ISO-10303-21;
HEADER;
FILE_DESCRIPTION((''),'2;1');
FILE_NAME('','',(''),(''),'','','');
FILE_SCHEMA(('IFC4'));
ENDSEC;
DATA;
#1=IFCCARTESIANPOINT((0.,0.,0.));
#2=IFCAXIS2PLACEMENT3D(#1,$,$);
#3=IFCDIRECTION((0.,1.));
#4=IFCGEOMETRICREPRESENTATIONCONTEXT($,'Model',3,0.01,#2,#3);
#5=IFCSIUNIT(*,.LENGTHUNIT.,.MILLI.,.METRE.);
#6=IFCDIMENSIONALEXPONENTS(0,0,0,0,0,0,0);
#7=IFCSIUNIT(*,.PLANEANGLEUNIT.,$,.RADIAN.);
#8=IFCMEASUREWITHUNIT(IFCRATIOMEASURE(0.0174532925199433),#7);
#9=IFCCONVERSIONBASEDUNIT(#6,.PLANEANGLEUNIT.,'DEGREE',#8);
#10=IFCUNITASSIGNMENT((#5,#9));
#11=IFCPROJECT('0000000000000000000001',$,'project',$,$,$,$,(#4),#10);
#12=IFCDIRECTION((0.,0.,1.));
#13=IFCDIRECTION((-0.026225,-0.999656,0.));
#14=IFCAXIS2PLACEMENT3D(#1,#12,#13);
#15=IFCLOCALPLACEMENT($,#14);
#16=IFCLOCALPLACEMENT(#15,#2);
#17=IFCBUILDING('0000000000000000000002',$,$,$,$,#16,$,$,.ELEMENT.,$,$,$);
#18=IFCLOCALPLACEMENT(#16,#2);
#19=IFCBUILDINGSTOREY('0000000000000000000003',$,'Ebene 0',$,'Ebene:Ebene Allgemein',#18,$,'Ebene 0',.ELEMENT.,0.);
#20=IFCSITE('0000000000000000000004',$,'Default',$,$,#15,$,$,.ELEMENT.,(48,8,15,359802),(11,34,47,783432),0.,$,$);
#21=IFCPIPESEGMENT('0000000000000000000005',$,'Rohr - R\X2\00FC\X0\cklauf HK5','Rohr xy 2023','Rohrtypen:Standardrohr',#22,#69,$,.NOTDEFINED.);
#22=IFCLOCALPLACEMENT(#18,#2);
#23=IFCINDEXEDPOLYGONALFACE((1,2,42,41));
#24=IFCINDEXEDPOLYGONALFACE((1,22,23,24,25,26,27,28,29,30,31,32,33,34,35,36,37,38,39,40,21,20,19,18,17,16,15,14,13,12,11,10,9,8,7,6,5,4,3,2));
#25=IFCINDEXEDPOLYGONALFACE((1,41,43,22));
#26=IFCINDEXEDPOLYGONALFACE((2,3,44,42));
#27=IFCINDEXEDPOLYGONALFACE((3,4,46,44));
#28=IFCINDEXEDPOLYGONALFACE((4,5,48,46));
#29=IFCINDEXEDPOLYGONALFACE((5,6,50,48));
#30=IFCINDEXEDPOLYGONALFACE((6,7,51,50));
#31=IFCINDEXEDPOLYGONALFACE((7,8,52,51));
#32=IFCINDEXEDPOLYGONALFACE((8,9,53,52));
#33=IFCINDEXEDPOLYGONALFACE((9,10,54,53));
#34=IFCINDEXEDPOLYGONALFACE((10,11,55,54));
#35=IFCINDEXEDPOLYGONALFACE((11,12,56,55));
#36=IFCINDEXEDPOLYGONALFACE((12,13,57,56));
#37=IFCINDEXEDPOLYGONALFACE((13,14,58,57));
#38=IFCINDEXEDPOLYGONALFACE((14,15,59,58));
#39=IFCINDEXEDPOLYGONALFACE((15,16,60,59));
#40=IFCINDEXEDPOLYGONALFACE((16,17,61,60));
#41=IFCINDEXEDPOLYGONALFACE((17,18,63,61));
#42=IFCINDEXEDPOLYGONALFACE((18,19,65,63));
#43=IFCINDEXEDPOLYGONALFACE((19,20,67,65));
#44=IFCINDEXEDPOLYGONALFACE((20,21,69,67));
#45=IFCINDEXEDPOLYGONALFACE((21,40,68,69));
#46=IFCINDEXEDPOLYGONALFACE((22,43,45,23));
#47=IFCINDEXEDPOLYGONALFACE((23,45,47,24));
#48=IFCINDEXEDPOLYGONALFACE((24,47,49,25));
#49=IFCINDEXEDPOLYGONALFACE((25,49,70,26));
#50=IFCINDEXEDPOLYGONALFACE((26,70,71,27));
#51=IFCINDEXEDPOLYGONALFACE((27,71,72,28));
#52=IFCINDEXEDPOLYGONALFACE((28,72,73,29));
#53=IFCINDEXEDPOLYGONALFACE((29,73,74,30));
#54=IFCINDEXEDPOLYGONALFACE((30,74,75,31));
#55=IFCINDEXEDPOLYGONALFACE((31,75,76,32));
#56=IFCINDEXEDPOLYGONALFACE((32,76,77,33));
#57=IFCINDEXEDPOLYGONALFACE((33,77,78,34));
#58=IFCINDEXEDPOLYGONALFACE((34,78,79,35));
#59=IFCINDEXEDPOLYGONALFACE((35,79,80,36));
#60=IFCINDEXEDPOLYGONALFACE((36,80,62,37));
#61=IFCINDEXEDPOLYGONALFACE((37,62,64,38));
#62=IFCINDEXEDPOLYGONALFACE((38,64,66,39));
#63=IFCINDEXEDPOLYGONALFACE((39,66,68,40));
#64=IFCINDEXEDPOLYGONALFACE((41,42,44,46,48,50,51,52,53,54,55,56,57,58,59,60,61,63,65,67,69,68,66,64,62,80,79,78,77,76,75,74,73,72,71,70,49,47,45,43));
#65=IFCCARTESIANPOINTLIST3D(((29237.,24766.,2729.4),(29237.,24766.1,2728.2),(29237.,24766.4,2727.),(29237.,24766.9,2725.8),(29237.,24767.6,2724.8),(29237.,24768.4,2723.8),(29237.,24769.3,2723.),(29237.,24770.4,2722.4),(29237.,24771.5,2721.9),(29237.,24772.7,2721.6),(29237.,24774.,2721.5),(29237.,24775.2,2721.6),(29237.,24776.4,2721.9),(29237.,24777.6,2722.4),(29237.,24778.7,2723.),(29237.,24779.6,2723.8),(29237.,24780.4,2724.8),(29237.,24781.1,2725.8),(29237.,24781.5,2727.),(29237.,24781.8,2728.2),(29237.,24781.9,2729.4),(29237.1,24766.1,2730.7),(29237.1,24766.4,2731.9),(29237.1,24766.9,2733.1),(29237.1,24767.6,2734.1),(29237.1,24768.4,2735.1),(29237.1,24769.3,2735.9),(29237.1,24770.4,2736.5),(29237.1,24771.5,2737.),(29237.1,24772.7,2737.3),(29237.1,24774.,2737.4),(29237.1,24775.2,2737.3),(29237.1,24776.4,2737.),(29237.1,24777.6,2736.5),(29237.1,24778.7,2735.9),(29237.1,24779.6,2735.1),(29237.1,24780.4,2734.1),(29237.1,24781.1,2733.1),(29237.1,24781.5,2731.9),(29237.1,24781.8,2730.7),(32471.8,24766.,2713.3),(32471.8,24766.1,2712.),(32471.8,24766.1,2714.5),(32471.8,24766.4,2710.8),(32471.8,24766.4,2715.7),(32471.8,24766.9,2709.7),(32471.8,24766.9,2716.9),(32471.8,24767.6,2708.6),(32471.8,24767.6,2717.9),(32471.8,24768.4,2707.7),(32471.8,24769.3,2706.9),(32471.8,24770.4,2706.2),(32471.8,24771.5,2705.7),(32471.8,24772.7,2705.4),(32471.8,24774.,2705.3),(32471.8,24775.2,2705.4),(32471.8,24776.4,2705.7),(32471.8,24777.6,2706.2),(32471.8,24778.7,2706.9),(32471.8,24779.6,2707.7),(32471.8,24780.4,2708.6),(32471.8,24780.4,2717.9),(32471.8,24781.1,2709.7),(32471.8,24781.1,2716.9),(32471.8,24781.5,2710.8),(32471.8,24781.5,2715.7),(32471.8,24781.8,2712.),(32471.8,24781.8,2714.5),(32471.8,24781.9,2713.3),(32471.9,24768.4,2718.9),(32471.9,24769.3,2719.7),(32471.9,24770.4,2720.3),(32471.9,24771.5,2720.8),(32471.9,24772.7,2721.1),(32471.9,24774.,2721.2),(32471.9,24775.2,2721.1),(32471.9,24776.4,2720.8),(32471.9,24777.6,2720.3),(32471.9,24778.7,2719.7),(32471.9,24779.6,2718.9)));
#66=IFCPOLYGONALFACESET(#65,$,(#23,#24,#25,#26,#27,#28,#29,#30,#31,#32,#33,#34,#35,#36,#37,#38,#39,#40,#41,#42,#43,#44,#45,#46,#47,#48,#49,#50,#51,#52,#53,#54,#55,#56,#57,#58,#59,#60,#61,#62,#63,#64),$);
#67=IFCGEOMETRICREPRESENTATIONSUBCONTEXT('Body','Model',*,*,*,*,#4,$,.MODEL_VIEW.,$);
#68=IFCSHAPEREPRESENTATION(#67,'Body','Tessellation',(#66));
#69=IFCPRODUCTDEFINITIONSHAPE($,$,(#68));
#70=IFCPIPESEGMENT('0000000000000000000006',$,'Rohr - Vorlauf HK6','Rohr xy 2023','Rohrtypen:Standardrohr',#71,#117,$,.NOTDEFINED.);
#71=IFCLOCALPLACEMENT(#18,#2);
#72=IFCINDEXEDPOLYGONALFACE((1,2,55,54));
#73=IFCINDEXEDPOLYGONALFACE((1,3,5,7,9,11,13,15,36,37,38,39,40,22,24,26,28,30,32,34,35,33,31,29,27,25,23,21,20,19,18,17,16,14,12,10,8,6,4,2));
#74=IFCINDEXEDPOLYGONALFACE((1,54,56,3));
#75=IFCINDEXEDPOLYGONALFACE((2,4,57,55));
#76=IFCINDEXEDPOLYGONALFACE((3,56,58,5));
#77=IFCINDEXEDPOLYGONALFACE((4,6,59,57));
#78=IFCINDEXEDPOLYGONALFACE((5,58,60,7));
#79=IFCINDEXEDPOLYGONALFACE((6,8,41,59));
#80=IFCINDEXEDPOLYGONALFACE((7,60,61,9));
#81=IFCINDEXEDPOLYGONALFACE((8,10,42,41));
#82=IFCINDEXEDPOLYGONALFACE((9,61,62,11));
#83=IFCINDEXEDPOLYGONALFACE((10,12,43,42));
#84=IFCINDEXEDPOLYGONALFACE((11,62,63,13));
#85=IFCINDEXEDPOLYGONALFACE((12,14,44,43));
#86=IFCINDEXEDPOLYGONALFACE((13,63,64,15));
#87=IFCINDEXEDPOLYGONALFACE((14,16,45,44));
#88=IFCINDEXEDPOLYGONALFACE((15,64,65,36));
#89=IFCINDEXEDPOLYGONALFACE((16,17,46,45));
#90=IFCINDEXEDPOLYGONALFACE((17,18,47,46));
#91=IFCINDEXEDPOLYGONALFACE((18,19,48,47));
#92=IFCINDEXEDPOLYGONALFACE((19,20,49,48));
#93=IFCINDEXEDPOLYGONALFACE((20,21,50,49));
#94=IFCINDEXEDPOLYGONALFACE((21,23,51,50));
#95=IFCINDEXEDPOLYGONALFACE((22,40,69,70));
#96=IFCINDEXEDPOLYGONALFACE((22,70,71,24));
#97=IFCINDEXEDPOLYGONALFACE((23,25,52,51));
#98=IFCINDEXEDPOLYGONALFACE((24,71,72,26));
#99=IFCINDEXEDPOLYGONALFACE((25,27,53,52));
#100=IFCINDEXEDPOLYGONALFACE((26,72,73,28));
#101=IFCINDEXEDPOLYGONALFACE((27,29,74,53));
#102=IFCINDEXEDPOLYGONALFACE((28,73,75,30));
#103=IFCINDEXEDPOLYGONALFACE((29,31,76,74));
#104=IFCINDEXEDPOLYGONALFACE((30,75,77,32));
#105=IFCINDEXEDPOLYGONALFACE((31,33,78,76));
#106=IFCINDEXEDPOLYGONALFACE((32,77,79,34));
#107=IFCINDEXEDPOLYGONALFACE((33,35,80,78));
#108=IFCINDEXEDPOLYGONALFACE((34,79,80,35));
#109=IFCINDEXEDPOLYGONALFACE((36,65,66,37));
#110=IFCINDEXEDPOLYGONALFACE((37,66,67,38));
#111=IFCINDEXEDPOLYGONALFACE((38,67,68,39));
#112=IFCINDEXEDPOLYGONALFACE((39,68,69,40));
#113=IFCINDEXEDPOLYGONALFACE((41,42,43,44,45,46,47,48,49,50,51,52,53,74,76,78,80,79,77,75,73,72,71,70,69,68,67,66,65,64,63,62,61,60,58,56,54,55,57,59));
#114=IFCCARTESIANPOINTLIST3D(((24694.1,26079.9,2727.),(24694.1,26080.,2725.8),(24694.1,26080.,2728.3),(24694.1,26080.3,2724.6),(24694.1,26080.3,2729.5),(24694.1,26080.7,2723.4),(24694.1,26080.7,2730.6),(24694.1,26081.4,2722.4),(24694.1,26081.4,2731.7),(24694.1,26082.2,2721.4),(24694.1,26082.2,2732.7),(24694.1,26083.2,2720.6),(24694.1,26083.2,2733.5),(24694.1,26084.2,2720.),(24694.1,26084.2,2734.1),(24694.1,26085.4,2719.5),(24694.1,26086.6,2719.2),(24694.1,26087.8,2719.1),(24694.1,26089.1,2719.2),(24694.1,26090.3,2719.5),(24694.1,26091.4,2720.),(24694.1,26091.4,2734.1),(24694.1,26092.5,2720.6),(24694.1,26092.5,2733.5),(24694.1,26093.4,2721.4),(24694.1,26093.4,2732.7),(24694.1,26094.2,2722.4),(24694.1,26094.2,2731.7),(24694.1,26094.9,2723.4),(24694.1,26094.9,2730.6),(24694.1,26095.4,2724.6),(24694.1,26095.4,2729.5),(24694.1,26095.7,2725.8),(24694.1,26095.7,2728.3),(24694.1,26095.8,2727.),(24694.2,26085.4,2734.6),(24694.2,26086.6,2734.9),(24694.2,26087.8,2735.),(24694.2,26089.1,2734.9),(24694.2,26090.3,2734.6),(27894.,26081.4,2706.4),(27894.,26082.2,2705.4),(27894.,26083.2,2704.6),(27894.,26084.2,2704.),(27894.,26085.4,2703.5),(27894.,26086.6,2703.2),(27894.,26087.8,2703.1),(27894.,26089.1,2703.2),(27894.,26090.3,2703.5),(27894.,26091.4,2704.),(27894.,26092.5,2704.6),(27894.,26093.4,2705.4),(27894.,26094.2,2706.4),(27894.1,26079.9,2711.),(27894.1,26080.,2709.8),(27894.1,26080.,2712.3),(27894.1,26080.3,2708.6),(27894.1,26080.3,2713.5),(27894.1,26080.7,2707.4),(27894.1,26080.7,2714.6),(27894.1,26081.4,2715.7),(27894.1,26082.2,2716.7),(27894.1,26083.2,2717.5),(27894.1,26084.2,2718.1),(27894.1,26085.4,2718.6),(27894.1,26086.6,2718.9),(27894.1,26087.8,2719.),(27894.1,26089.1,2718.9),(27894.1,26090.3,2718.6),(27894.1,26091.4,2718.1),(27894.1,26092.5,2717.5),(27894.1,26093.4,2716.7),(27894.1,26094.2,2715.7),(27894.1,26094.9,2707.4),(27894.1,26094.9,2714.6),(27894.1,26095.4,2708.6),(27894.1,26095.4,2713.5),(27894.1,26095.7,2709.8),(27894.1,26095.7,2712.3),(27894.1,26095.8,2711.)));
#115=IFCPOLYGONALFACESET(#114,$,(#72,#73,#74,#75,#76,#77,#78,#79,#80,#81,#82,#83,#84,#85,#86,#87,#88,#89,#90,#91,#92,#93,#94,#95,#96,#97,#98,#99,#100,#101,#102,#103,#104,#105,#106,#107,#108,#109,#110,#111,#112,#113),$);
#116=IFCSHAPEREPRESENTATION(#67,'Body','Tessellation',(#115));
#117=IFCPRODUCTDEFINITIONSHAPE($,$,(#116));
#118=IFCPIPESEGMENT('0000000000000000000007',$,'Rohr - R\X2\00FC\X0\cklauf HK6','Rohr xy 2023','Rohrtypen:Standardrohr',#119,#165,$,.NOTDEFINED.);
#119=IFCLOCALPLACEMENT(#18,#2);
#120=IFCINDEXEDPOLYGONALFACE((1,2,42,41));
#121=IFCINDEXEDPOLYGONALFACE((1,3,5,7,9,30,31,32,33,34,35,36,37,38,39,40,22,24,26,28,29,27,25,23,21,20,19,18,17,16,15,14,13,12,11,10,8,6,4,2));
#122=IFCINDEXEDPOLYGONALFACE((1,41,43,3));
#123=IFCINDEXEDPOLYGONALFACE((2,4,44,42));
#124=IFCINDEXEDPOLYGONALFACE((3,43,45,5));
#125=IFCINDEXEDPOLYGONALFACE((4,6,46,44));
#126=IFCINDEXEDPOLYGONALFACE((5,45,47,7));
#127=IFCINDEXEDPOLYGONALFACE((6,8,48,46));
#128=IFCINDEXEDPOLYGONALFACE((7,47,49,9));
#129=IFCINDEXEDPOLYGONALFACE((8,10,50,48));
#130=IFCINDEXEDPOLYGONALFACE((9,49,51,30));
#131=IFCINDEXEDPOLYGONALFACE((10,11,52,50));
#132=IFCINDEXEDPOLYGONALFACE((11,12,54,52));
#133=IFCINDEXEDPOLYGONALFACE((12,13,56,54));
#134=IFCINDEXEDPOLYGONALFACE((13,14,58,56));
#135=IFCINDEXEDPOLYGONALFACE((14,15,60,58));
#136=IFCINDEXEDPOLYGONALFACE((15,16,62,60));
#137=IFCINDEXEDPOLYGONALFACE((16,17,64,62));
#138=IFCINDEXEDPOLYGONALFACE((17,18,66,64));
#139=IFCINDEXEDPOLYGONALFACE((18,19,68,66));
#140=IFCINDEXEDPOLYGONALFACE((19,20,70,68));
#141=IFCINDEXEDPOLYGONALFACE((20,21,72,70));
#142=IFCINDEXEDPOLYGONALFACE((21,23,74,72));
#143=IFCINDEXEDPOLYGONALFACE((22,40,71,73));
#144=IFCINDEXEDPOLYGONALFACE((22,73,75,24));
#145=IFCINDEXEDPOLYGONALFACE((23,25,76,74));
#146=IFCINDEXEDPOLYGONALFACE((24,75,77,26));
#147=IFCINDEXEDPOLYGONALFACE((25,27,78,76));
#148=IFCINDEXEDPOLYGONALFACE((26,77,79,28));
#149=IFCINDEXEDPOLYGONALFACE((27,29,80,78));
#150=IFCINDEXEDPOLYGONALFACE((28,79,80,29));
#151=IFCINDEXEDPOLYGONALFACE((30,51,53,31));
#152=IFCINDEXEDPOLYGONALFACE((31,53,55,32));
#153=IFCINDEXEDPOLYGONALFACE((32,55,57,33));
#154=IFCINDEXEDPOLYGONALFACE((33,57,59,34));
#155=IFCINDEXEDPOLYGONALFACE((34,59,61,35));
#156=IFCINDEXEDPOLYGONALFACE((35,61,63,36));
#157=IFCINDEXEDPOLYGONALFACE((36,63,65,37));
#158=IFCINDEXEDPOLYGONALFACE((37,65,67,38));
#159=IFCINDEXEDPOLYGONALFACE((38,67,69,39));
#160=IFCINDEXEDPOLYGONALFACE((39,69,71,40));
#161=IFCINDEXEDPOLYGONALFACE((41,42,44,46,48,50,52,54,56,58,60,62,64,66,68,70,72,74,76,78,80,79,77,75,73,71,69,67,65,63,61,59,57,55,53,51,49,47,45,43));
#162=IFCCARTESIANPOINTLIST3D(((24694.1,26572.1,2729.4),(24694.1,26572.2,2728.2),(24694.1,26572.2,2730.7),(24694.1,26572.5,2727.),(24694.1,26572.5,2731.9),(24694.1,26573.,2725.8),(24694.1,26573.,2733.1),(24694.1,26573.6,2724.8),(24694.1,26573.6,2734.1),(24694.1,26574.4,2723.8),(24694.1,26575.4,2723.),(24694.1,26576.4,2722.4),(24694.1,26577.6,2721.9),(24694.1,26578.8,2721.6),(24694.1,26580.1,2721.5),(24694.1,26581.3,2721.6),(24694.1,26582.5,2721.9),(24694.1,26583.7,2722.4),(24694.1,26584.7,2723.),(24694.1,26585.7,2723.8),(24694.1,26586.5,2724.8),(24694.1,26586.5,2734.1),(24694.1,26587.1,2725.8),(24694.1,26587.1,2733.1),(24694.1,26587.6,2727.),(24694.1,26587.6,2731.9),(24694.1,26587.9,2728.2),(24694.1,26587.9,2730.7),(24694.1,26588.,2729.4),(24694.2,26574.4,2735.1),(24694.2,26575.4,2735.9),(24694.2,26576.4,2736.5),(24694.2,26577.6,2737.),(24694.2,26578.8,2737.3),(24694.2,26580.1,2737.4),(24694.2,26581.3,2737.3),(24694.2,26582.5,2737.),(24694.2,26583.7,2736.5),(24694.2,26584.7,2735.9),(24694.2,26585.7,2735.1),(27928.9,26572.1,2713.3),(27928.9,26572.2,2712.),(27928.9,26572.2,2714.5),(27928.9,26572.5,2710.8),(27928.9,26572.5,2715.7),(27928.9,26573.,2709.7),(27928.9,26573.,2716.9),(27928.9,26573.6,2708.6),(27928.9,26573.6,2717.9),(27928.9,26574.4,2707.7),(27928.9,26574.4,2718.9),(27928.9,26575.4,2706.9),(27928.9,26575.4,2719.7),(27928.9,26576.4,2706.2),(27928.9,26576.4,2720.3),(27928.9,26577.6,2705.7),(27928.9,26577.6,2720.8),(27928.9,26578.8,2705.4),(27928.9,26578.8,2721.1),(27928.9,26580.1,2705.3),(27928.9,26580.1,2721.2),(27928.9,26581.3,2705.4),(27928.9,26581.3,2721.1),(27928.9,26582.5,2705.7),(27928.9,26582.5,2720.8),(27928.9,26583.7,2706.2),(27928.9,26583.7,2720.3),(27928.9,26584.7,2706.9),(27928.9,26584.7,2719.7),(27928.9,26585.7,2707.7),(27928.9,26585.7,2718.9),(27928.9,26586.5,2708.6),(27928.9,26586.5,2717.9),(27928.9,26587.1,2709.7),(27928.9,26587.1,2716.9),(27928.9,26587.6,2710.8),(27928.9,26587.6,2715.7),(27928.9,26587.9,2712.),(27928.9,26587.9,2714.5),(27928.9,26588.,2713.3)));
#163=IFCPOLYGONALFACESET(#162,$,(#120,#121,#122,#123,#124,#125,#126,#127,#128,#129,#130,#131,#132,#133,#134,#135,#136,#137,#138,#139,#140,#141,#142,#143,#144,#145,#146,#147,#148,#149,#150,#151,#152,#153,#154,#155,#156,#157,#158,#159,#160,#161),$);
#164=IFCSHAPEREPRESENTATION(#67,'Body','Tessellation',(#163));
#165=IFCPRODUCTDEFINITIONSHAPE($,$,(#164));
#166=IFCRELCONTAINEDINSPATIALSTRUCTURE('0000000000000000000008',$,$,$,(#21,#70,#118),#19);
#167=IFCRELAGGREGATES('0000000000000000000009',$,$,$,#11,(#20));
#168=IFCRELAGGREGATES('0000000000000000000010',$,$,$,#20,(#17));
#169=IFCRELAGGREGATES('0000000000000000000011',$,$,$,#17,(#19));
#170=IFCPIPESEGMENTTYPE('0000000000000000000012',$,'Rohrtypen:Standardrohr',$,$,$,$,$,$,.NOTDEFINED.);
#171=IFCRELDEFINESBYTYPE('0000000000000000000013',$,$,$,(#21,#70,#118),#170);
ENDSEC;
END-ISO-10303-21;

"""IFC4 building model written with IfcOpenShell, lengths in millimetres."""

from ifc_helpers import new_model, entity, si_unit, converted_unit, direction, frame, origin, place, context, subcontext, project, spatial, indexed_curve, outline, extrude, type_object, element, save


model = new_model("IFC4")

# Units and contexts
model_context = context("Model", 3, precision=0.01, world=origin(), true_north=direction((0.0, 1.0)))
body_context = subcontext(model_context, "Body", "Model", "MODEL_VIEW")
ifc_project = project(units=[si_unit("LENGTHUNIT", "METRE", prefix="MILLI"), converted_unit("PLANEANGLEUNIT", "DEGREE", entity("IfcRatioMeasure", 0.0174532925199433), si_unit("PLANEANGLEUNIT", "RADIAN"), dimensions=[0, 0, 0, 0, 0, 0, 0])], contexts=[model_context])

# Site, building, storey
site_placement = place(None, frame((0.0, 0.0, 0.0), z_axis=(0.0, 0.0, 1.0), x_axis=(-0.026225, -0.999656, 0.0)))
site = spatial("IfcSite", under=ifc_project, at=site_placement, Name="Default", CompositionType="ELEMENT", RefLatitude=(48, 8, 15, 359802), RefLongitude=(11, 34, 47, 783432), RefElevation=0.0)
building_placement = place(site_placement, origin())
building = spatial("IfcBuilding", under=site, at=building_placement, CompositionType="ELEMENT")
storey_placement = place(building_placement, origin())
storey = spatial("IfcBuildingStorey", under=building, at=storey_placement, Name="Ebene 0", ObjectType="Ebene:Ebene Allgemein", LongName="Ebene 0", CompositionType="ELEMENT", Elevation=0.0)

# Pipe segments
pipe_segment_type = type_object("IfcPipeSegmentType", Name="Rohrtypen:Standardrohr", PredefinedType="NOTDEFINED")
pipe_segment_1_placement = place(storey_placement, origin())
element("IfcPipeSegment", 1, at=pipe_segment_1_placement, inside=storey, type_object=pipe_segment_type, Name="Rohr - Rücklauf HK5", Description="Rohr xy 2023", ObjectType="Rohrtypen:Standardrohr", PredefinedType="NOTDEFINED", context=body_context, shape_type="SweptSolid", body=[
    extrude(outline(indexed_curve([(7.9, 0.0), (7.8, 1.2), (7.6, 2.5), (7.1, 3.6), (6.4, 4.7), (5.6, 5.6), (4.7, 6.4), (3.6, 7.1), (2.5, 7.6), (1.2, 7.8), (0.0, 7.9), (-1.2, 7.8), (-2.5, 7.6), (-3.6, 7.1), (-4.7, 6.4), (-5.6, 5.6), (-6.4, 4.7), (-7.1, 3.6), (-7.6, 2.5), (-7.8, 1.2), (-7.9, 0.0), (-7.8, -1.2), (-7.6, -2.5), (-7.1, -3.6), (-6.4, -4.7), (-5.6, -5.6), (-4.7, -6.4), (-3.6, -7.1), (-2.5, -7.6), (-1.2, -7.8), (0.0, -7.9), (1.2, -7.8), (2.5, -7.6), (3.6, -7.1), (4.7, -6.4), (5.6, -5.6), (6.4, -4.7), (7.1, -3.6), (7.6, -2.5), (7.8, -1.2), (7.9, 0.0)], self_intersect=False)), frame((32471.8, 24774.0, 2713.3), z_axis=(-0.999988, 0.0, 0.005), x_axis=(0.0, 1.0, 0.0)), (0.0, 0.0, 1.0), 3234.8),
])
pipe_segment_2_placement = place(storey_placement, origin())
element("IfcPipeSegment", 2, at=pipe_segment_2_placement, inside=storey, type_object=pipe_segment_type, Name="Rohr - Vorlauf HK6", Description="Rohr xy 2023", ObjectType="Rohrtypen:Standardrohr", PredefinedType="NOTDEFINED", context=body_context, shape_type="SweptSolid", body=[
    extrude(outline(indexed_curve([(7.9, 0.0), (7.8, 1.2), (7.6, 2.5), (7.1, 3.6), (6.4, 4.7), (5.6, 5.6), (4.7, 6.4), (3.6, 7.1), (2.5, 7.6), (1.2, 7.8), (0.0, 7.9), (-1.2, 7.8), (-2.5, 7.6), (-3.6, 7.1), (-4.7, 6.4), (-5.6, 5.6), (-6.4, 4.7), (-7.1, 3.6), (-7.6, 2.5), (-7.8, 1.2), (-7.9, 0.0), (-7.8, -1.2), (-7.6, -2.5), (-7.1, -3.6), (-6.4, -4.7), (-5.6, -5.6), (-4.7, -6.4), (-3.6, -7.1), (-2.5, -7.6), (-1.2, -7.8), (0.0, -7.9), (1.2, -7.8), (2.5, -7.6), (3.6, -7.1), (4.7, -6.4), (5.6, -5.6), (6.4, -4.7), (7.1, -3.6), (7.6, -2.5), (7.8, -1.2), (7.9, 0.0)], self_intersect=False)), frame((27894.1, 26087.8, 2711.0), z_axis=(-0.999988, 0.0, 0.005), x_axis=(0.0, 1.0, 0.0)), (0.0, 0.0, 1.0), 3200.0),
])
pipe_segment_3_placement = place(storey_placement, origin())
element("IfcPipeSegment", 3, at=pipe_segment_3_placement, inside=storey, type_object=pipe_segment_type, Name="Rohr - Rücklauf HK6", Description="Rohr xy 2023", ObjectType="Rohrtypen:Standardrohr", PredefinedType="NOTDEFINED", context=body_context, shape_type="SweptSolid", body=[
    extrude(outline(indexed_curve([(7.9, 0.0), (7.8, 1.2), (7.6, 2.5), (7.1, 3.6), (6.4, 4.7), (5.6, 5.6), (4.7, 6.4), (3.6, 7.1), (2.5, 7.6), (1.2, 7.8), (0.0, 7.9), (-1.2, 7.8), (-2.5, 7.6), (-3.6, 7.1), (-4.7, 6.4), (-5.6, 5.6), (-6.4, 4.7), (-7.1, 3.6), (-7.6, 2.5), (-7.8, 1.2), (-7.9, 0.0), (-7.8, -1.2), (-7.6, -2.5), (-7.1, -3.6), (-6.4, -4.7), (-5.6, -5.6), (-4.7, -6.4), (-3.6, -7.1), (-2.5, -7.6), (-1.2, -7.8), (0.0, -7.9), (1.2, -7.8), (2.5, -7.6), (3.6, -7.1), (4.7, -6.4), (5.6, -5.6), (6.4, -4.7), (7.1, -3.6), (7.6, -2.5), (7.8, -1.2), (7.9, 0.0)], self_intersect=False)), frame((27928.9, 26580.1, 2713.3), z_axis=(-0.999988, 0.0, 0.005), x_axis=(0.0, 1.0, 0.0)), (0.0, 0.0, 1.0), 3234.8),
])

save(model, "model.ifc")
